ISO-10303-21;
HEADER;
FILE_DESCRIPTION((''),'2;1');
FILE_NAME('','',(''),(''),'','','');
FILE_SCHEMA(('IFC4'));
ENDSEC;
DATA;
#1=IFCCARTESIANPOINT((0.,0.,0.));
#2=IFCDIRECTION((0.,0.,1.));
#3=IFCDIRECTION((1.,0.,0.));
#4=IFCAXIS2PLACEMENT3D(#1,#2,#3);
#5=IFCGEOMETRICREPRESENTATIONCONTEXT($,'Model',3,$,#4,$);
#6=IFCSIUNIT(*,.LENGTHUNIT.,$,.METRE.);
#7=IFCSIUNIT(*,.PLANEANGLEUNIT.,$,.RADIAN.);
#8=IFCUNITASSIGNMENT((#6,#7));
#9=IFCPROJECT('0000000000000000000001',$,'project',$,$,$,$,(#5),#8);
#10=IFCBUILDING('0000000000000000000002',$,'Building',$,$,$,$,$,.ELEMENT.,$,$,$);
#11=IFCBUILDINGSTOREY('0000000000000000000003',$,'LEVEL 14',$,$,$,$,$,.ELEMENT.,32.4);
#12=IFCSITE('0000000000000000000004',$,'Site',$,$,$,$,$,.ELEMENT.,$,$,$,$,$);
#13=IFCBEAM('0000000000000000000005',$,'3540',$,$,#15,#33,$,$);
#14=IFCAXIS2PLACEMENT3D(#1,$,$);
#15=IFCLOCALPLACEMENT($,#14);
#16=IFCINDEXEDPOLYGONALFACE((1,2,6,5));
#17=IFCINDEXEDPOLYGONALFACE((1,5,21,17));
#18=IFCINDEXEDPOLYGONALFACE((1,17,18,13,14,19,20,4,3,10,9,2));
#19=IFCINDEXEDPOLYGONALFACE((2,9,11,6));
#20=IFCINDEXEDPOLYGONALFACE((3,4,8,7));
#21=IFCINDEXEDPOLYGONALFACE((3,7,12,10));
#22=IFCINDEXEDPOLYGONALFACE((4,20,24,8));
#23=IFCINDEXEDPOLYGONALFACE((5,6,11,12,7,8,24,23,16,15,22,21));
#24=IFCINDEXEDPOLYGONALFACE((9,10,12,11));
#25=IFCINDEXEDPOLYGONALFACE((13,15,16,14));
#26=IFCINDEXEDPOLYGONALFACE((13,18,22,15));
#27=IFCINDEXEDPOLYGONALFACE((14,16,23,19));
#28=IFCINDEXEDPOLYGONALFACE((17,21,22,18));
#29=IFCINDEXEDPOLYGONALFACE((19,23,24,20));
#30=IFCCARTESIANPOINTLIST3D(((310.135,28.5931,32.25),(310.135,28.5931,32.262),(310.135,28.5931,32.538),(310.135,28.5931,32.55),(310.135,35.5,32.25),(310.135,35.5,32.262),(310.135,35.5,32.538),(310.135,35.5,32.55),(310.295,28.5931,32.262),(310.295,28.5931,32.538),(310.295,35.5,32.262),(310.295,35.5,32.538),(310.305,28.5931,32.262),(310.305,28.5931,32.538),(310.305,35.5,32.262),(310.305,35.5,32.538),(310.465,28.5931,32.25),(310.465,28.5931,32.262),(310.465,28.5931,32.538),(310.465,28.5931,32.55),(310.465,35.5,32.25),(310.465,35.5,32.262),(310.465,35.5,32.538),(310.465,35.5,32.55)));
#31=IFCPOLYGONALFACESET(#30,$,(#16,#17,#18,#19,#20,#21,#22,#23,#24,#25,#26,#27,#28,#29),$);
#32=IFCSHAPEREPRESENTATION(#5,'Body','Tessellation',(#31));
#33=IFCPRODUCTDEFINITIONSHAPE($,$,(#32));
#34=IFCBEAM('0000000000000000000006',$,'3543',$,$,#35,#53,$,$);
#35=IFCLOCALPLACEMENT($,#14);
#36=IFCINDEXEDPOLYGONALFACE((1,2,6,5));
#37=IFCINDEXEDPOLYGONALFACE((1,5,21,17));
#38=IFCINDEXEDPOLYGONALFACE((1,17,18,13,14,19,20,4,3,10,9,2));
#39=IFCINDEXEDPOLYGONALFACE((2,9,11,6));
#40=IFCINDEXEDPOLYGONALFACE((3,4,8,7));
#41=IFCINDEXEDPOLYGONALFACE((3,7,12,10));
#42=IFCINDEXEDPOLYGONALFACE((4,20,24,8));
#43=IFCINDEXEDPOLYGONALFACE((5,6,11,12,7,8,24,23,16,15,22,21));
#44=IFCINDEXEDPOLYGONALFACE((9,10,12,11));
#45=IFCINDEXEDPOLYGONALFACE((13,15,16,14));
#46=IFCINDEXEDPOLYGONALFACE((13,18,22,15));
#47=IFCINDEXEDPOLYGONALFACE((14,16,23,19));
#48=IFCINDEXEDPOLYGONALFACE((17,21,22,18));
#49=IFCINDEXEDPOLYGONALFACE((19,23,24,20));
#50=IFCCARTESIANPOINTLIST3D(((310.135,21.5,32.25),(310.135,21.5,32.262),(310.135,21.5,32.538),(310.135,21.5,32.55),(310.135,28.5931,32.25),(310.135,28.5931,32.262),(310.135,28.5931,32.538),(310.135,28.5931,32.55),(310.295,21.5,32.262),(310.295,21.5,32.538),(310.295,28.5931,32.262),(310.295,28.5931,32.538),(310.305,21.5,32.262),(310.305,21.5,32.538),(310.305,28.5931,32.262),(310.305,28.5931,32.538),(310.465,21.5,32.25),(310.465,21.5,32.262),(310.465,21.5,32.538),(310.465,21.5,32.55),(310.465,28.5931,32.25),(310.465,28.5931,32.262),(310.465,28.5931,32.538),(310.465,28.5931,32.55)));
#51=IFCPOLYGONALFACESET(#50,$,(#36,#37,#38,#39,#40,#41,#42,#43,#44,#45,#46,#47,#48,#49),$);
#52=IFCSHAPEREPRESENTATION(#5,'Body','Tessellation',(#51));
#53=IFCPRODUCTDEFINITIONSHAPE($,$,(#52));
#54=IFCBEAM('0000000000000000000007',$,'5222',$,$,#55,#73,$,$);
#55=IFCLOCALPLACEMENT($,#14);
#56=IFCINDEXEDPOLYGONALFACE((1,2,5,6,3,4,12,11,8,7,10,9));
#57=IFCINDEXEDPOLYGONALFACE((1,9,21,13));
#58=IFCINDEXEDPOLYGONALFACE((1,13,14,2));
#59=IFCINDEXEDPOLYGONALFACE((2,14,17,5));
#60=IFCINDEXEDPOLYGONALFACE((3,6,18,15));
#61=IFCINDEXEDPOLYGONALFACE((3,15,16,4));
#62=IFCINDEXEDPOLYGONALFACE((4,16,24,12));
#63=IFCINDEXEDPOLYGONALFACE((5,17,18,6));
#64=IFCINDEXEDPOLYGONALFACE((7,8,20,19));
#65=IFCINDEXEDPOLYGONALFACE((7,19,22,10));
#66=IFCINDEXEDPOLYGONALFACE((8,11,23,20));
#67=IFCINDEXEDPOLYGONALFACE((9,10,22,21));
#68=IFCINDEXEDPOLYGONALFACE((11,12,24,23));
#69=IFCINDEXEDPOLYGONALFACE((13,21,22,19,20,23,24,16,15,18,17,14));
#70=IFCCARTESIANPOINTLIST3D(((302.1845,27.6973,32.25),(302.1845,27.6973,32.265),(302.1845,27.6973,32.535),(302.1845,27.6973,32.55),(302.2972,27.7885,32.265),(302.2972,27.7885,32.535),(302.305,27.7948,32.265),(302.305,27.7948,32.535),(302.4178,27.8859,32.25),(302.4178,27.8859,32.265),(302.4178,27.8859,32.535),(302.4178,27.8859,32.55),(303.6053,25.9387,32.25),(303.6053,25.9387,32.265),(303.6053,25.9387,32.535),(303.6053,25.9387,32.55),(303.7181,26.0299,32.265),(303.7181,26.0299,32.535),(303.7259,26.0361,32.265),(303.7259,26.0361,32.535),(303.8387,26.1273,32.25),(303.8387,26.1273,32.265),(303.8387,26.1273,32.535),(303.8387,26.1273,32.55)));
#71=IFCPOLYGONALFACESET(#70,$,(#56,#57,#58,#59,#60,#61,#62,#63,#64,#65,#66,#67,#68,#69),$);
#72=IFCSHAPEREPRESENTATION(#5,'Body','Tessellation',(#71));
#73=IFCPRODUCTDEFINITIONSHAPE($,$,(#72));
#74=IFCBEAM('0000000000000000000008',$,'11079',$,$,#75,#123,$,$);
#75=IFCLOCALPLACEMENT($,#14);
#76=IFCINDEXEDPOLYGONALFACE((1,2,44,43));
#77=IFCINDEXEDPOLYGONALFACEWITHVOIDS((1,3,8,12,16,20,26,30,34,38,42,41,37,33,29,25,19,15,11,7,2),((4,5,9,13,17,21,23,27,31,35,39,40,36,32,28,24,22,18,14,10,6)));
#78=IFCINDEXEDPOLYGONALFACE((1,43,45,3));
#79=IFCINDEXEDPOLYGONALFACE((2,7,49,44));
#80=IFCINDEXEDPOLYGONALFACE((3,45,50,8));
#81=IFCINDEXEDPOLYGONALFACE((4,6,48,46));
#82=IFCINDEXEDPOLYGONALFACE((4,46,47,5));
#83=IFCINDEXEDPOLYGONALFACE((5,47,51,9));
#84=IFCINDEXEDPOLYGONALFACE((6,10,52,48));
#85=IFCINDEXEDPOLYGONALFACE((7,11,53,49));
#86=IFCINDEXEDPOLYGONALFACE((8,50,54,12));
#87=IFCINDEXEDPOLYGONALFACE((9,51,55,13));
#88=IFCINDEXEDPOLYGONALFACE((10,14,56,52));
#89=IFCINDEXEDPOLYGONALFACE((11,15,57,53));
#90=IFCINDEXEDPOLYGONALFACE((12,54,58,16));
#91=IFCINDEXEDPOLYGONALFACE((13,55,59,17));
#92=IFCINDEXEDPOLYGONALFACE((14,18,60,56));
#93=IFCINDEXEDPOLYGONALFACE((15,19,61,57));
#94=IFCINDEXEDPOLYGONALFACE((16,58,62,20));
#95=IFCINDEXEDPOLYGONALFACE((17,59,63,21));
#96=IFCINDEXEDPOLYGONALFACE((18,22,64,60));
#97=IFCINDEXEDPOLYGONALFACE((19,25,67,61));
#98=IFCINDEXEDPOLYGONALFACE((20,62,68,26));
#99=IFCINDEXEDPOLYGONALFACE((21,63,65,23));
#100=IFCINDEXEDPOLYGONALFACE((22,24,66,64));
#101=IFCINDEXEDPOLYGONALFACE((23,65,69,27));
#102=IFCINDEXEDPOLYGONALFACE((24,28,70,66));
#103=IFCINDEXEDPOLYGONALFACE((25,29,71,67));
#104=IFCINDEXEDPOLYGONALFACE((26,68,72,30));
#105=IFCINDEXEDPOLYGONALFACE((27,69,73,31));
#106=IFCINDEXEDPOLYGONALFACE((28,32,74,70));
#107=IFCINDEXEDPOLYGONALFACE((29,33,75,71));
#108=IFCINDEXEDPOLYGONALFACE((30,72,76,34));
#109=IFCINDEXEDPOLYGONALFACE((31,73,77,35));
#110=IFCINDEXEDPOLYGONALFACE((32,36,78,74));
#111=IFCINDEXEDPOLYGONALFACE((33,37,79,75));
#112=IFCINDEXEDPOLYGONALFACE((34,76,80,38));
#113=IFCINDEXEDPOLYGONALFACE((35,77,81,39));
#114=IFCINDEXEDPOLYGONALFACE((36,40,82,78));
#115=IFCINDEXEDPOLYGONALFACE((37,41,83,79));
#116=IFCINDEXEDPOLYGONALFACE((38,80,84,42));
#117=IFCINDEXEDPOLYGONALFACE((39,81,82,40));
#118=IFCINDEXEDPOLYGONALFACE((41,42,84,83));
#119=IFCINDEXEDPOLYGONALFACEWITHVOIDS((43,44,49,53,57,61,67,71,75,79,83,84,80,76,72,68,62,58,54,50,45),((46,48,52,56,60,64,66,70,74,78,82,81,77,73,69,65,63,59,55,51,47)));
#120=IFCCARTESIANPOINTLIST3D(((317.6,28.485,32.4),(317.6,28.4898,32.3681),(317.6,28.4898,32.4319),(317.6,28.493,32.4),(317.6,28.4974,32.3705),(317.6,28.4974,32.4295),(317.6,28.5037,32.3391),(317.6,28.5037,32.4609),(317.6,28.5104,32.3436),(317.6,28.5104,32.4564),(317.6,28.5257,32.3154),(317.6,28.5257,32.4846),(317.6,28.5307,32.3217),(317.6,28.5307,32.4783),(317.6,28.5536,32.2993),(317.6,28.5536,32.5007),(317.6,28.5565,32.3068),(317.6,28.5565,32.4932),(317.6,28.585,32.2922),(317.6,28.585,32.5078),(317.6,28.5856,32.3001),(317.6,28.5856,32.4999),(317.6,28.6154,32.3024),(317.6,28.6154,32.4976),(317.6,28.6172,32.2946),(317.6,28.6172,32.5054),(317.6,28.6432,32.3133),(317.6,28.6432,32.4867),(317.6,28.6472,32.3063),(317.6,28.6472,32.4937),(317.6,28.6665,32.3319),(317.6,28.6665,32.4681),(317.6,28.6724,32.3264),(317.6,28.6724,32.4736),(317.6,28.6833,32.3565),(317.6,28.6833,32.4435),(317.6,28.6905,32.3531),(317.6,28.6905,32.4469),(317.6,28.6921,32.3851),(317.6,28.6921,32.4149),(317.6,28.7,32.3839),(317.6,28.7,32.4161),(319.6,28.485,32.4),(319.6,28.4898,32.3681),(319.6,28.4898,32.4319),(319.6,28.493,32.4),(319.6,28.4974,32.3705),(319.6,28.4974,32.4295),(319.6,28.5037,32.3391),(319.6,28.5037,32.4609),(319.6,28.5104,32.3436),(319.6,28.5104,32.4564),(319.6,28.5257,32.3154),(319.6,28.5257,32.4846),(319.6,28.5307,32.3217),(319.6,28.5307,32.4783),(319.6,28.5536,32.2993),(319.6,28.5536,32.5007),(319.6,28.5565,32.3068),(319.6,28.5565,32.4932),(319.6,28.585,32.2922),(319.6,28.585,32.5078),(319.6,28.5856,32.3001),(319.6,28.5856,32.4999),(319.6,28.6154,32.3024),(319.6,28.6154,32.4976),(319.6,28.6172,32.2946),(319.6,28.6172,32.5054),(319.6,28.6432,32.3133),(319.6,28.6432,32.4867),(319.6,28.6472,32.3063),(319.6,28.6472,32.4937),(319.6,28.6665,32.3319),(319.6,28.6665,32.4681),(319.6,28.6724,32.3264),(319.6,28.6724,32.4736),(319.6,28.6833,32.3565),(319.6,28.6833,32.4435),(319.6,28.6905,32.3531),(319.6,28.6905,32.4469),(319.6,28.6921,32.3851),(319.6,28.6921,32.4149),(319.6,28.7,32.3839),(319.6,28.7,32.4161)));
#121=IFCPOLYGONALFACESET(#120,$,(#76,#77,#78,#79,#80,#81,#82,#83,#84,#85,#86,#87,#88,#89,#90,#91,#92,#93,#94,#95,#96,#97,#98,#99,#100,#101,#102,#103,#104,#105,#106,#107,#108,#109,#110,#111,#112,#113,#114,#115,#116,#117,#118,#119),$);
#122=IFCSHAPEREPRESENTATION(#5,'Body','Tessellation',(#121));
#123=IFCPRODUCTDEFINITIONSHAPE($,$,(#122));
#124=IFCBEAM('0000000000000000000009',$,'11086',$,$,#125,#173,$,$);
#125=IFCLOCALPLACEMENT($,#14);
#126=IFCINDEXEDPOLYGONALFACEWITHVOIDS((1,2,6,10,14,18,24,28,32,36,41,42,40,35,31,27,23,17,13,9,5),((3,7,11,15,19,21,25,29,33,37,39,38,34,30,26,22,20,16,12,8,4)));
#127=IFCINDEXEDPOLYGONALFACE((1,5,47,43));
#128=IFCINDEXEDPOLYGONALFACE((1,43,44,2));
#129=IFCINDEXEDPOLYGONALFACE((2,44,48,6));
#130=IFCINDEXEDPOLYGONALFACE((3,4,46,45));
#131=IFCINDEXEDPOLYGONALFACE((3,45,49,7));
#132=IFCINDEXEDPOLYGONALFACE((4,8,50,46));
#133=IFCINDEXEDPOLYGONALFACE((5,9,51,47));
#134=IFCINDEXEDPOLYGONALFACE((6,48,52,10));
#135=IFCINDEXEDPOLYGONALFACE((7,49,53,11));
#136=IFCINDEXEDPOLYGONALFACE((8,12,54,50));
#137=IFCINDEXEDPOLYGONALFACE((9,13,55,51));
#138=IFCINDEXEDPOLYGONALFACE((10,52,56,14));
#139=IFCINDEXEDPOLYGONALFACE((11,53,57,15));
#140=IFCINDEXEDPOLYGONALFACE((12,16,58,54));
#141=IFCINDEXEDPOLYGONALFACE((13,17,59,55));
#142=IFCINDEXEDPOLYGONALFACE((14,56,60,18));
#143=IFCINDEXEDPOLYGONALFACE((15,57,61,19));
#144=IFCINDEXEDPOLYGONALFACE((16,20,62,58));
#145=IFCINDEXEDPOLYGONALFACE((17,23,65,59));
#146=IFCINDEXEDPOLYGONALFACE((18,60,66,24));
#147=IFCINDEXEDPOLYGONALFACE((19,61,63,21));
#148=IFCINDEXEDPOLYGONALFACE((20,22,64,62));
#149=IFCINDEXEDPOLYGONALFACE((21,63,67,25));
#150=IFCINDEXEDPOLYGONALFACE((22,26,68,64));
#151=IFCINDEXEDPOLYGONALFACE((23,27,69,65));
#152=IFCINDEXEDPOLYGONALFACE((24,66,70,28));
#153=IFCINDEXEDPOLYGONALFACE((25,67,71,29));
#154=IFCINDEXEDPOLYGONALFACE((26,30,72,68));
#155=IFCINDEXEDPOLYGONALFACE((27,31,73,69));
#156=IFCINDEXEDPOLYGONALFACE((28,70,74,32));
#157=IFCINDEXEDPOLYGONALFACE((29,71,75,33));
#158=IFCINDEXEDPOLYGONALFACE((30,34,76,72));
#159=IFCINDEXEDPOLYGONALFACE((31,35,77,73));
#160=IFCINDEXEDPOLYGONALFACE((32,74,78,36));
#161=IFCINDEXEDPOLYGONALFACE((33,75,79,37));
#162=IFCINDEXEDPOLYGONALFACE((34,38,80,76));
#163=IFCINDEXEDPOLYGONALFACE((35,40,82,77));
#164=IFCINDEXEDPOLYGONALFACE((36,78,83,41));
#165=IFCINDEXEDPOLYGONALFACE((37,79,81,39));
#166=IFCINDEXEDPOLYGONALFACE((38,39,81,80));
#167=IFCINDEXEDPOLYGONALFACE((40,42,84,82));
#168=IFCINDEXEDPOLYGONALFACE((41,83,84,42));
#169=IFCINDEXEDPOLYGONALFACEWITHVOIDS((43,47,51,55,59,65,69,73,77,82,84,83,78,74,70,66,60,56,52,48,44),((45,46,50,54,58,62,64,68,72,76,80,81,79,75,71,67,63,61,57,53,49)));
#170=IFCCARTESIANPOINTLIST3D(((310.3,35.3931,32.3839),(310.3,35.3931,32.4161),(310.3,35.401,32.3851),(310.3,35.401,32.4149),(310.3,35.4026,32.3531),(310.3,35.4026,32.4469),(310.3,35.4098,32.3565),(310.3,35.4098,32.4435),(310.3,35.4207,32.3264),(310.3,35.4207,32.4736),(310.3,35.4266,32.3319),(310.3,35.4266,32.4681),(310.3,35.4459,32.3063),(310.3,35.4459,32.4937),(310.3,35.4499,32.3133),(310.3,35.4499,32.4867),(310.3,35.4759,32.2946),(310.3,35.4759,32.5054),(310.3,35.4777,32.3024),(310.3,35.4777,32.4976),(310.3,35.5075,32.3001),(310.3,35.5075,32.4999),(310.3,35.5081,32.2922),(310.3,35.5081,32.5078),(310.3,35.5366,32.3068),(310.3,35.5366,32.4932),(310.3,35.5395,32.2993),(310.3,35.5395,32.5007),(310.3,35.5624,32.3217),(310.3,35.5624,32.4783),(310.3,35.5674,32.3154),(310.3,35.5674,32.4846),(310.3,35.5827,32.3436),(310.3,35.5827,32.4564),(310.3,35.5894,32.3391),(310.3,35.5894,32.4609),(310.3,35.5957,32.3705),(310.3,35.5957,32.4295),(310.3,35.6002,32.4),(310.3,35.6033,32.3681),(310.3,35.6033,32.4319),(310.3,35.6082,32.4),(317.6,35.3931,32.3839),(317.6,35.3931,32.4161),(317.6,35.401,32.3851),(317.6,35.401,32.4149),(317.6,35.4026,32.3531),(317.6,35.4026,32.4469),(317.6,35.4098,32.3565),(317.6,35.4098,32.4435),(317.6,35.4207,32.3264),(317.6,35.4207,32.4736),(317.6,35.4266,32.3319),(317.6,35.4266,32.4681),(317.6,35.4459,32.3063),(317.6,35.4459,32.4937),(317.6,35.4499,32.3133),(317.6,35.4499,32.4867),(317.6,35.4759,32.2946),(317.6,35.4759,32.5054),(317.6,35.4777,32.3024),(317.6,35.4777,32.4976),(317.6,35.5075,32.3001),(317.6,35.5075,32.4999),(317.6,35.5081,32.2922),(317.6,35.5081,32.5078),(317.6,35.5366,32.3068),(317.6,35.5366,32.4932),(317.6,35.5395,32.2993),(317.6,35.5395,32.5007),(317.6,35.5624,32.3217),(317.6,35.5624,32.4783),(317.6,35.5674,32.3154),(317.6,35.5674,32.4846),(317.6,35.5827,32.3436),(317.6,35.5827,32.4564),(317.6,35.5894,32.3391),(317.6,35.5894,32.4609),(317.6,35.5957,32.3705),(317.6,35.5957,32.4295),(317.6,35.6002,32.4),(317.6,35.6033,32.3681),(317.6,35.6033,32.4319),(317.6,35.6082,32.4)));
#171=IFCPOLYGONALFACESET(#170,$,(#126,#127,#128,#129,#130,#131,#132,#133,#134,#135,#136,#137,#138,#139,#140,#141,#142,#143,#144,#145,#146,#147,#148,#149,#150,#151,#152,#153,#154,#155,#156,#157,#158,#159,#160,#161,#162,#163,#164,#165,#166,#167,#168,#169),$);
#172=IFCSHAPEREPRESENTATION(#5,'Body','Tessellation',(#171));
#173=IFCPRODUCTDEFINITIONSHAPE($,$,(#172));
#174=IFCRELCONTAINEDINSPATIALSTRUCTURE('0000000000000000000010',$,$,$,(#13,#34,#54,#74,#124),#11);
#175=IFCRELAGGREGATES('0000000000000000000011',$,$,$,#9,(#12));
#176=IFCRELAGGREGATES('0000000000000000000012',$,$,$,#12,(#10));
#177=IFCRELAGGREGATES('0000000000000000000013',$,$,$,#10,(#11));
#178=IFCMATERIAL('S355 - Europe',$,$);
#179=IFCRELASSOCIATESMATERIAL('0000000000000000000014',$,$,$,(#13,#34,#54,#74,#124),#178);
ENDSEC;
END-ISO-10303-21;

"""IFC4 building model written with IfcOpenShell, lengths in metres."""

from ifc_helpers import new_model, si_unit, frame, origin_with_axes, origin_2d_with_axis, place, context, project, spatial, hollow_circle, i_section, extrude, material, material_profile, profile_set, profile_usage, element, save


model = new_model("IFC4")

# Units and contexts
model_context = context("Model", 3, world=origin_with_axes())
ifc_project = project(units=[si_unit("LENGTHUNIT", "METRE"), si_unit("PLANEANGLEUNIT", "RADIAN")], contexts=[model_context])

# Site, building, storey
site = spatial("IfcSite", under=ifc_project, Name="Site", CompositionType="ELEMENT")
building = spatial("IfcBuilding", under=site, Name="Building", CompositionType="ELEMENT")
storey = spatial("IfcBuildingStorey", under=building, Name="LEVEL 14", CompositionType="ELEMENT", Elevation=32.4)

# Shared definitions
ifc_material = material(Name="S355 - Europe")

# Beams
ifc_material_profile_1 = material_profile(ifc_material, i_section(OverallWidth=0.33, OverallDepth=0.3, WebThickness=0.01, FlangeThickness=0.012, at=origin_2d_with_axis()))
ifc_profile_set_1 = profile_set([ifc_material_profile_1])
ifc_profile_usage_1 = profile_usage(ifc_profile_set_1, cardinal=10)
beam_1_placement = place(None, frame((310.3, 35.5, 32.4), z_axis=(0.0, -1.0, 0.0), x_axis=(1.0, 0.0, 0.0)))
element("IfcBeam", 1, at=beam_1_placement, inside=storey, material=ifc_profile_usage_1, Name="3540", context=model_context, shape_type="SweptSolid", body=[
    extrude(i_section(OverallWidth=0.33, OverallDepth=0.3, WebThickness=0.01, FlangeThickness=0.012, at=origin_2d_with_axis()), origin_with_axes(), (0.0, 0.0, 1.0), 6.9069),
])
ifc_material_profile_2 = material_profile(ifc_material, i_section(OverallWidth=0.33, OverallDepth=0.3, WebThickness=0.01, FlangeThickness=0.012, at=origin_2d_with_axis()))
ifc_profile_set_2 = profile_set([ifc_material_profile_2])
ifc_profile_usage_2 = profile_usage(ifc_profile_set_2, cardinal=10)
beam_2_placement = place(None, frame((310.3, 28.5931, 32.4), z_axis=(0.0, -1.0, 0.0), x_axis=(1.0, 0.0, 0.0)))
element("IfcBeam", 2, at=beam_2_placement, inside=storey, material=ifc_profile_usage_2, Name="3543", context=model_context, shape_type="SweptSolid", body=[
    extrude(i_section(OverallWidth=0.33, OverallDepth=0.3, WebThickness=0.01, FlangeThickness=0.012, at=origin_2d_with_axis()), origin_with_axes(), (0.0, 0.0, 1.0), 7.0931),
])
ifc_material_profile_3 = material_profile(ifc_material, i_section(OverallWidth=0.3, OverallDepth=0.3, WebThickness=0.01, FlangeThickness=0.015, at=origin_2d_with_axis()))
ifc_profile_set_3 = profile_set([ifc_material_profile_3])
ifc_profile_usage_3 = profile_usage(ifc_profile_set_3, cardinal=10)
beam_3_placement = place(None, frame((303.722, 26.033, 32.4), z_axis=(-0.628459, 0.777842, 0.0), x_axis=(-0.77747, -0.62892, 0.0)))
element("IfcBeam", 3, at=beam_3_placement, inside=storey, material=ifc_profile_usage_3, Name="5222", context=model_context, shape_type="SweptSolid", body=[
    extrude(i_section(OverallWidth=0.3, OverallDepth=0.3, WebThickness=0.01, FlangeThickness=0.015, at=origin_2d_with_axis()), origin_with_axes(), (0.0, 0.0, 1.0), 2.2609),
])
ifc_material_profile_4 = material_profile(ifc_material, hollow_circle(Radius=0.1081, WallThickness=0.008, at=origin_2d_with_axis()))
ifc_profile_set_4 = profile_set([ifc_material_profile_4])
ifc_profile_usage_4 = profile_usage(ifc_profile_set_4, cardinal=10)
beam_4_placement = place(None, frame((319.6, 28.5931, 32.4), z_axis=(-1.0, 0.0, 0.0), x_axis=(0.0, -1.0, 0.0)))
element("IfcBeam", 4, at=beam_4_placement, inside=storey, material=ifc_profile_usage_4, Name="11079", context=model_context, shape_type="SweptSolid", body=[
    extrude(hollow_circle(Radius=0.1081, WallThickness=0.008, at=origin_2d_with_axis()), origin_with_axes(), (0.0, 0.0, 1.0), 2.0),
])
ifc_material_profile_5 = material_profile(ifc_material, hollow_circle(Radius=0.1081, WallThickness=0.008, at=origin_2d_with_axis()))
ifc_profile_set_5 = profile_set([ifc_material_profile_5])
ifc_profile_usage_5 = profile_usage(ifc_profile_set_5, cardinal=10)
beam_5_placement = place(None, frame((310.3, 35.5, 32.4), z_axis=(1.0, 0.0, 0.0), x_axis=(0.0, 1.0, 0.0)))
element("IfcBeam", 5, at=beam_5_placement, inside=storey, material=ifc_profile_usage_5, Name="11086", context=model_context, shape_type="SweptSolid", body=[
    extrude(hollow_circle(Radius=0.1081, WallThickness=0.008, at=origin_2d_with_axis()), origin_with_axes(), (0.0, 0.0, 1.0), 7.3),
])

save(model, "model.ifc")
